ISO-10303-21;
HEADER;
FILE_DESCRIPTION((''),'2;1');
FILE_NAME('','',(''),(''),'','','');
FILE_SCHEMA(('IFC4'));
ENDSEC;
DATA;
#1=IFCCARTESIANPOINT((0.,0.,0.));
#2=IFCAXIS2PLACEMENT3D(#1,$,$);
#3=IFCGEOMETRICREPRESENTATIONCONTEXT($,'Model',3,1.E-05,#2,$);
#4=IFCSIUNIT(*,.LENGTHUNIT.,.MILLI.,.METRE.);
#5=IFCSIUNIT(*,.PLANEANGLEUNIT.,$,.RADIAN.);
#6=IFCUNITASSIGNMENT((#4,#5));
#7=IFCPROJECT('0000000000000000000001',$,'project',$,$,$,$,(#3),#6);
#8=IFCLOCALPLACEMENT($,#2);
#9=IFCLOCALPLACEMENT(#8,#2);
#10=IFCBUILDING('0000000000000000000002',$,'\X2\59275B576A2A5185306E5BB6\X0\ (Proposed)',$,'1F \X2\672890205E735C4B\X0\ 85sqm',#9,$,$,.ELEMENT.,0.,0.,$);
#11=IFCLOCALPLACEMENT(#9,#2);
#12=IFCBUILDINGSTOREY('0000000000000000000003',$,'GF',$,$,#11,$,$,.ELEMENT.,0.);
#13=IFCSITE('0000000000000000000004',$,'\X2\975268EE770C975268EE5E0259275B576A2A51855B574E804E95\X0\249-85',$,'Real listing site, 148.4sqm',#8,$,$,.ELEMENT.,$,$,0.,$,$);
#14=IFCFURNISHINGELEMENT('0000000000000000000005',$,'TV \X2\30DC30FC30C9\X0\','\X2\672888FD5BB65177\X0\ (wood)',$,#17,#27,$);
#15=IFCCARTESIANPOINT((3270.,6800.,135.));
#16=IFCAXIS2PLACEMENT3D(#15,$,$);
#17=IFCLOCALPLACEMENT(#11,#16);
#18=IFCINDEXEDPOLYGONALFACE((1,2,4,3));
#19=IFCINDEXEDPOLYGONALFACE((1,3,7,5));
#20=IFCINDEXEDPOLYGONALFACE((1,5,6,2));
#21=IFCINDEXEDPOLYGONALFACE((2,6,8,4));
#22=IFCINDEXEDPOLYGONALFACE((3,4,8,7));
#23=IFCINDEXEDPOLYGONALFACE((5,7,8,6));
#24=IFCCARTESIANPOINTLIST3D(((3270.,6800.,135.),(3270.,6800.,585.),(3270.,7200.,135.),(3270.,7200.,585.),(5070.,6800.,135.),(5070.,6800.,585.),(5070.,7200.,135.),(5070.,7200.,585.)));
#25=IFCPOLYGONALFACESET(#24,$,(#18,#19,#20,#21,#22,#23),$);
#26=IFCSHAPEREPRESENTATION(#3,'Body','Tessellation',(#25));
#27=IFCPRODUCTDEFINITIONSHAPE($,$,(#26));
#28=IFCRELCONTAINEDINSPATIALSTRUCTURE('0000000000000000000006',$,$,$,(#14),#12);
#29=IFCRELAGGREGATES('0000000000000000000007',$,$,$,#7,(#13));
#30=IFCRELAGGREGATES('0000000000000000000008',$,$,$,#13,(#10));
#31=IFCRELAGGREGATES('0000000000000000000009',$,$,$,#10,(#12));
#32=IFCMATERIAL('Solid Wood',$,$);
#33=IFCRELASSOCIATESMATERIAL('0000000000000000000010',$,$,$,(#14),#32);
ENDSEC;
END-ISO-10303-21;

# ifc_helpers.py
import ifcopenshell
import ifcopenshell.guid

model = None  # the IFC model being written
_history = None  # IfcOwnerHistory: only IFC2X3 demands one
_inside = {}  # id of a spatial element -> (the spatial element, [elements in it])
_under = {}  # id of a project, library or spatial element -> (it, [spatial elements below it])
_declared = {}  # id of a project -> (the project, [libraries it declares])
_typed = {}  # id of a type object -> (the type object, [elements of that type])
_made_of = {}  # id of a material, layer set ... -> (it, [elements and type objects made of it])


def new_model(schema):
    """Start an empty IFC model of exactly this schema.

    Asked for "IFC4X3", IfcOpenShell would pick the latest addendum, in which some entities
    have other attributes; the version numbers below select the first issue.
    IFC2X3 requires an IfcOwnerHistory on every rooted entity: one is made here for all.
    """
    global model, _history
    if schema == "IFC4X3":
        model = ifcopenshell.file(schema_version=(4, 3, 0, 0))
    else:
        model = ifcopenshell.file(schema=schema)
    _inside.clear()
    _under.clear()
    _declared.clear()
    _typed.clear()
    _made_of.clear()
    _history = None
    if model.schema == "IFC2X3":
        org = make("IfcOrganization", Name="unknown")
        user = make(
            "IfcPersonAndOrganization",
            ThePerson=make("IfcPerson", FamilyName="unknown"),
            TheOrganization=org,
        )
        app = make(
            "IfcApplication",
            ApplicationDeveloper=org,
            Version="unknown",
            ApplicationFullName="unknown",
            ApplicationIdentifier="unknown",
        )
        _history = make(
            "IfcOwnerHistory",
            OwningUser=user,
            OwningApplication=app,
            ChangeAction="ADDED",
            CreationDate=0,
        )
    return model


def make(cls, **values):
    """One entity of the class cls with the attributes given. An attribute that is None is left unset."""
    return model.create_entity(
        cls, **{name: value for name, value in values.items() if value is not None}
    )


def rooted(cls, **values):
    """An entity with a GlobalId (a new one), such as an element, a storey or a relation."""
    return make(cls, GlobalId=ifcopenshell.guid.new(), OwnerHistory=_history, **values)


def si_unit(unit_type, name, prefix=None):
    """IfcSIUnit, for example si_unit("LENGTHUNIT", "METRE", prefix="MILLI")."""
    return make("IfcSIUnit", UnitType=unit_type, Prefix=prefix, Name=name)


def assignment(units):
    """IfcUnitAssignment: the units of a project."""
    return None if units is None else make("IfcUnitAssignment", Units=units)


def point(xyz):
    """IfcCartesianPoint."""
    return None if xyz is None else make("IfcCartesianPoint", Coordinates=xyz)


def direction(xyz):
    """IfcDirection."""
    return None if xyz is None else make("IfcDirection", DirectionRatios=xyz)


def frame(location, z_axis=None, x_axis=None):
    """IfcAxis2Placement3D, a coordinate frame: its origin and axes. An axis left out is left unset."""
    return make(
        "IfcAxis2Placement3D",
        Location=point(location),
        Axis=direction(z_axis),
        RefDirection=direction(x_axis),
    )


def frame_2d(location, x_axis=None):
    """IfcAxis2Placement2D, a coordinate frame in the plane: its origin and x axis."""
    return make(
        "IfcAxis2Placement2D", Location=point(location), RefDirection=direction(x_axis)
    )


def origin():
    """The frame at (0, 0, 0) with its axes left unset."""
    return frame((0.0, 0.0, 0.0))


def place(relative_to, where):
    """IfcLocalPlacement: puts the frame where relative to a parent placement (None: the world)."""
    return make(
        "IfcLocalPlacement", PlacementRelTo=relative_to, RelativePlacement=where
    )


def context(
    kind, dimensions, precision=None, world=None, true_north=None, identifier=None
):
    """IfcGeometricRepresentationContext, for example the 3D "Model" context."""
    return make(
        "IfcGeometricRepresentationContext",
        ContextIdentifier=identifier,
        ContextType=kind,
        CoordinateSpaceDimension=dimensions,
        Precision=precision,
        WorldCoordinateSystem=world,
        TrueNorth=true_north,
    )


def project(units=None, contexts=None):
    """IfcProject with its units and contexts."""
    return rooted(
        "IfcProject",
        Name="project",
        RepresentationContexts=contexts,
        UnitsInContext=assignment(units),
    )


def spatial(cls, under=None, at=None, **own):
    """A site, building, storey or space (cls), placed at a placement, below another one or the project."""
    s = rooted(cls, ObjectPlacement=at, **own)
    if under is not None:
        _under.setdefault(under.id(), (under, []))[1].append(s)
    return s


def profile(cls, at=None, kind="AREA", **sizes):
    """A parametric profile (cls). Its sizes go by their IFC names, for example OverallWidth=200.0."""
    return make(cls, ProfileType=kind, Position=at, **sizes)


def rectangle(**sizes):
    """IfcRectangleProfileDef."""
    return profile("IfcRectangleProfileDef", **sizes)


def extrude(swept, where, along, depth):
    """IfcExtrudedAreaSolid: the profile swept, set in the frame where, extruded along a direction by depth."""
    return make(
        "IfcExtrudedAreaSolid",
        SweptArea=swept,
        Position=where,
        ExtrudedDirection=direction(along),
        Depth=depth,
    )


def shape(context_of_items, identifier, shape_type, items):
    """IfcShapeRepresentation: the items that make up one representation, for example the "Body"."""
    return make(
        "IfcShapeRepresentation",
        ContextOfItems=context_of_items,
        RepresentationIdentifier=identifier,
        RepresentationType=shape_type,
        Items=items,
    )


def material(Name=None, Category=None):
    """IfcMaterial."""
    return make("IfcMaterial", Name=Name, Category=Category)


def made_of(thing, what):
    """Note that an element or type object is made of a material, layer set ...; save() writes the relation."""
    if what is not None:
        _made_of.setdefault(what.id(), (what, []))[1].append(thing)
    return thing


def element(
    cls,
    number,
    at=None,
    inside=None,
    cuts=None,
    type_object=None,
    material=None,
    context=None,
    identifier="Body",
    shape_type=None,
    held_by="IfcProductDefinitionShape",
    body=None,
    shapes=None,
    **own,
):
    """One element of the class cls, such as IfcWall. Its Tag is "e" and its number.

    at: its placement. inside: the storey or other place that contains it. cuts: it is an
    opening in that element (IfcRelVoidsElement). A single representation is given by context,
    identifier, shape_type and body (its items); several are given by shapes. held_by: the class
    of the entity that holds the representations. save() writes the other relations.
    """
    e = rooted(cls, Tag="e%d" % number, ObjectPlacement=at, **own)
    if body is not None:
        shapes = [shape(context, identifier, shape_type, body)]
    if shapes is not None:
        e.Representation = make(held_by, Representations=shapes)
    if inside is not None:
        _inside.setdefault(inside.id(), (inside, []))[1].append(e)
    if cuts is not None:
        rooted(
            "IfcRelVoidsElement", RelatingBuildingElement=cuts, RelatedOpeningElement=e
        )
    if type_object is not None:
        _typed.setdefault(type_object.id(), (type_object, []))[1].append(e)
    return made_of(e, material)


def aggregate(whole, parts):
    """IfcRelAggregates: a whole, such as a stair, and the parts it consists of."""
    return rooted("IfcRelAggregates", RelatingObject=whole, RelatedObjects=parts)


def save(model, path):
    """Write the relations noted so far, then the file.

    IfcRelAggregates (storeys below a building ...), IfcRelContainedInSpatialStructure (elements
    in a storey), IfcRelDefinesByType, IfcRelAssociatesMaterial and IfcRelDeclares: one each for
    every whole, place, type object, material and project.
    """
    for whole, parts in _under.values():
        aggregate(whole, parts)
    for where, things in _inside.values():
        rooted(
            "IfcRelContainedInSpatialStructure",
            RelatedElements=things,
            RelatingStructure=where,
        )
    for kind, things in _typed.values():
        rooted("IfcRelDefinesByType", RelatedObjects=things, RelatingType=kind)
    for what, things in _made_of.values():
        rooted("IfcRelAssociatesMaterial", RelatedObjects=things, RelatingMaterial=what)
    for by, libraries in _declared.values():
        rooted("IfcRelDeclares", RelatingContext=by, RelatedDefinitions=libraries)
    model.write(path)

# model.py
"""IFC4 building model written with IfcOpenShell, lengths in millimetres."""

from ifc_helpers import new_model, si_unit, frame, frame_2d, origin, place, context, project, spatial, rectangle, extrude, material, element, save


model = new_model("IFC4")

# Units and contexts
model_context = context("Model", 3, precision=1e-05, world=origin())
ifc_project = project(units=[si_unit("LENGTHUNIT", "METRE", prefix="MILLI"), si_unit("PLANEANGLEUNIT", "RADIAN")], contexts=[model_context])

# Site, building, storey
site_placement = place(None, origin())
site = spatial("IfcSite", under=ifc_project, at=site_placement, Name="青森県青森市大字横内字亀井249-85", ObjectType="Real listing site, 148.4sqm", CompositionType="ELEMENT", RefElevation=0.0)
building_placement = place(site_placement, origin())
building = spatial("IfcBuilding", under=site, at=building_placement, Name="大字横内の家 (Proposed)", ObjectType="1F 木造平屋 85sqm", CompositionType="ELEMENT", ElevationOfRefHeight=0.0, ElevationOfTerrain=0.0)
storey_placement = place(building_placement, origin())
storey = spatial("IfcBuildingStorey", under=building, at=storey_placement, Name="GF", CompositionType="ELEMENT", Elevation=0.0)

# Shared definitions
ifc_material_1 = material(Name="Solid Wood")

# Furnishing element
furnishing_1_placement = place(storey_placement, frame((3270.0, 6800.0, 135.0)))
element("IfcFurnishingElement", 1, at=furnishing_1_placement, inside=storey, material=ifc_material_1, Name="TV ボード", Description="木製家具 (wood)", context=model_context, shape_type="SweptSolid", body=[
    extrude(rectangle(XDim=1800.0, YDim=400.0, at=frame_2d((900.0, 200.0))), frame((3270.0, 6800.0, 135.0)), (0.0, 0.0, 1.0), 450.0),
])

save(model, "model.ifc")
